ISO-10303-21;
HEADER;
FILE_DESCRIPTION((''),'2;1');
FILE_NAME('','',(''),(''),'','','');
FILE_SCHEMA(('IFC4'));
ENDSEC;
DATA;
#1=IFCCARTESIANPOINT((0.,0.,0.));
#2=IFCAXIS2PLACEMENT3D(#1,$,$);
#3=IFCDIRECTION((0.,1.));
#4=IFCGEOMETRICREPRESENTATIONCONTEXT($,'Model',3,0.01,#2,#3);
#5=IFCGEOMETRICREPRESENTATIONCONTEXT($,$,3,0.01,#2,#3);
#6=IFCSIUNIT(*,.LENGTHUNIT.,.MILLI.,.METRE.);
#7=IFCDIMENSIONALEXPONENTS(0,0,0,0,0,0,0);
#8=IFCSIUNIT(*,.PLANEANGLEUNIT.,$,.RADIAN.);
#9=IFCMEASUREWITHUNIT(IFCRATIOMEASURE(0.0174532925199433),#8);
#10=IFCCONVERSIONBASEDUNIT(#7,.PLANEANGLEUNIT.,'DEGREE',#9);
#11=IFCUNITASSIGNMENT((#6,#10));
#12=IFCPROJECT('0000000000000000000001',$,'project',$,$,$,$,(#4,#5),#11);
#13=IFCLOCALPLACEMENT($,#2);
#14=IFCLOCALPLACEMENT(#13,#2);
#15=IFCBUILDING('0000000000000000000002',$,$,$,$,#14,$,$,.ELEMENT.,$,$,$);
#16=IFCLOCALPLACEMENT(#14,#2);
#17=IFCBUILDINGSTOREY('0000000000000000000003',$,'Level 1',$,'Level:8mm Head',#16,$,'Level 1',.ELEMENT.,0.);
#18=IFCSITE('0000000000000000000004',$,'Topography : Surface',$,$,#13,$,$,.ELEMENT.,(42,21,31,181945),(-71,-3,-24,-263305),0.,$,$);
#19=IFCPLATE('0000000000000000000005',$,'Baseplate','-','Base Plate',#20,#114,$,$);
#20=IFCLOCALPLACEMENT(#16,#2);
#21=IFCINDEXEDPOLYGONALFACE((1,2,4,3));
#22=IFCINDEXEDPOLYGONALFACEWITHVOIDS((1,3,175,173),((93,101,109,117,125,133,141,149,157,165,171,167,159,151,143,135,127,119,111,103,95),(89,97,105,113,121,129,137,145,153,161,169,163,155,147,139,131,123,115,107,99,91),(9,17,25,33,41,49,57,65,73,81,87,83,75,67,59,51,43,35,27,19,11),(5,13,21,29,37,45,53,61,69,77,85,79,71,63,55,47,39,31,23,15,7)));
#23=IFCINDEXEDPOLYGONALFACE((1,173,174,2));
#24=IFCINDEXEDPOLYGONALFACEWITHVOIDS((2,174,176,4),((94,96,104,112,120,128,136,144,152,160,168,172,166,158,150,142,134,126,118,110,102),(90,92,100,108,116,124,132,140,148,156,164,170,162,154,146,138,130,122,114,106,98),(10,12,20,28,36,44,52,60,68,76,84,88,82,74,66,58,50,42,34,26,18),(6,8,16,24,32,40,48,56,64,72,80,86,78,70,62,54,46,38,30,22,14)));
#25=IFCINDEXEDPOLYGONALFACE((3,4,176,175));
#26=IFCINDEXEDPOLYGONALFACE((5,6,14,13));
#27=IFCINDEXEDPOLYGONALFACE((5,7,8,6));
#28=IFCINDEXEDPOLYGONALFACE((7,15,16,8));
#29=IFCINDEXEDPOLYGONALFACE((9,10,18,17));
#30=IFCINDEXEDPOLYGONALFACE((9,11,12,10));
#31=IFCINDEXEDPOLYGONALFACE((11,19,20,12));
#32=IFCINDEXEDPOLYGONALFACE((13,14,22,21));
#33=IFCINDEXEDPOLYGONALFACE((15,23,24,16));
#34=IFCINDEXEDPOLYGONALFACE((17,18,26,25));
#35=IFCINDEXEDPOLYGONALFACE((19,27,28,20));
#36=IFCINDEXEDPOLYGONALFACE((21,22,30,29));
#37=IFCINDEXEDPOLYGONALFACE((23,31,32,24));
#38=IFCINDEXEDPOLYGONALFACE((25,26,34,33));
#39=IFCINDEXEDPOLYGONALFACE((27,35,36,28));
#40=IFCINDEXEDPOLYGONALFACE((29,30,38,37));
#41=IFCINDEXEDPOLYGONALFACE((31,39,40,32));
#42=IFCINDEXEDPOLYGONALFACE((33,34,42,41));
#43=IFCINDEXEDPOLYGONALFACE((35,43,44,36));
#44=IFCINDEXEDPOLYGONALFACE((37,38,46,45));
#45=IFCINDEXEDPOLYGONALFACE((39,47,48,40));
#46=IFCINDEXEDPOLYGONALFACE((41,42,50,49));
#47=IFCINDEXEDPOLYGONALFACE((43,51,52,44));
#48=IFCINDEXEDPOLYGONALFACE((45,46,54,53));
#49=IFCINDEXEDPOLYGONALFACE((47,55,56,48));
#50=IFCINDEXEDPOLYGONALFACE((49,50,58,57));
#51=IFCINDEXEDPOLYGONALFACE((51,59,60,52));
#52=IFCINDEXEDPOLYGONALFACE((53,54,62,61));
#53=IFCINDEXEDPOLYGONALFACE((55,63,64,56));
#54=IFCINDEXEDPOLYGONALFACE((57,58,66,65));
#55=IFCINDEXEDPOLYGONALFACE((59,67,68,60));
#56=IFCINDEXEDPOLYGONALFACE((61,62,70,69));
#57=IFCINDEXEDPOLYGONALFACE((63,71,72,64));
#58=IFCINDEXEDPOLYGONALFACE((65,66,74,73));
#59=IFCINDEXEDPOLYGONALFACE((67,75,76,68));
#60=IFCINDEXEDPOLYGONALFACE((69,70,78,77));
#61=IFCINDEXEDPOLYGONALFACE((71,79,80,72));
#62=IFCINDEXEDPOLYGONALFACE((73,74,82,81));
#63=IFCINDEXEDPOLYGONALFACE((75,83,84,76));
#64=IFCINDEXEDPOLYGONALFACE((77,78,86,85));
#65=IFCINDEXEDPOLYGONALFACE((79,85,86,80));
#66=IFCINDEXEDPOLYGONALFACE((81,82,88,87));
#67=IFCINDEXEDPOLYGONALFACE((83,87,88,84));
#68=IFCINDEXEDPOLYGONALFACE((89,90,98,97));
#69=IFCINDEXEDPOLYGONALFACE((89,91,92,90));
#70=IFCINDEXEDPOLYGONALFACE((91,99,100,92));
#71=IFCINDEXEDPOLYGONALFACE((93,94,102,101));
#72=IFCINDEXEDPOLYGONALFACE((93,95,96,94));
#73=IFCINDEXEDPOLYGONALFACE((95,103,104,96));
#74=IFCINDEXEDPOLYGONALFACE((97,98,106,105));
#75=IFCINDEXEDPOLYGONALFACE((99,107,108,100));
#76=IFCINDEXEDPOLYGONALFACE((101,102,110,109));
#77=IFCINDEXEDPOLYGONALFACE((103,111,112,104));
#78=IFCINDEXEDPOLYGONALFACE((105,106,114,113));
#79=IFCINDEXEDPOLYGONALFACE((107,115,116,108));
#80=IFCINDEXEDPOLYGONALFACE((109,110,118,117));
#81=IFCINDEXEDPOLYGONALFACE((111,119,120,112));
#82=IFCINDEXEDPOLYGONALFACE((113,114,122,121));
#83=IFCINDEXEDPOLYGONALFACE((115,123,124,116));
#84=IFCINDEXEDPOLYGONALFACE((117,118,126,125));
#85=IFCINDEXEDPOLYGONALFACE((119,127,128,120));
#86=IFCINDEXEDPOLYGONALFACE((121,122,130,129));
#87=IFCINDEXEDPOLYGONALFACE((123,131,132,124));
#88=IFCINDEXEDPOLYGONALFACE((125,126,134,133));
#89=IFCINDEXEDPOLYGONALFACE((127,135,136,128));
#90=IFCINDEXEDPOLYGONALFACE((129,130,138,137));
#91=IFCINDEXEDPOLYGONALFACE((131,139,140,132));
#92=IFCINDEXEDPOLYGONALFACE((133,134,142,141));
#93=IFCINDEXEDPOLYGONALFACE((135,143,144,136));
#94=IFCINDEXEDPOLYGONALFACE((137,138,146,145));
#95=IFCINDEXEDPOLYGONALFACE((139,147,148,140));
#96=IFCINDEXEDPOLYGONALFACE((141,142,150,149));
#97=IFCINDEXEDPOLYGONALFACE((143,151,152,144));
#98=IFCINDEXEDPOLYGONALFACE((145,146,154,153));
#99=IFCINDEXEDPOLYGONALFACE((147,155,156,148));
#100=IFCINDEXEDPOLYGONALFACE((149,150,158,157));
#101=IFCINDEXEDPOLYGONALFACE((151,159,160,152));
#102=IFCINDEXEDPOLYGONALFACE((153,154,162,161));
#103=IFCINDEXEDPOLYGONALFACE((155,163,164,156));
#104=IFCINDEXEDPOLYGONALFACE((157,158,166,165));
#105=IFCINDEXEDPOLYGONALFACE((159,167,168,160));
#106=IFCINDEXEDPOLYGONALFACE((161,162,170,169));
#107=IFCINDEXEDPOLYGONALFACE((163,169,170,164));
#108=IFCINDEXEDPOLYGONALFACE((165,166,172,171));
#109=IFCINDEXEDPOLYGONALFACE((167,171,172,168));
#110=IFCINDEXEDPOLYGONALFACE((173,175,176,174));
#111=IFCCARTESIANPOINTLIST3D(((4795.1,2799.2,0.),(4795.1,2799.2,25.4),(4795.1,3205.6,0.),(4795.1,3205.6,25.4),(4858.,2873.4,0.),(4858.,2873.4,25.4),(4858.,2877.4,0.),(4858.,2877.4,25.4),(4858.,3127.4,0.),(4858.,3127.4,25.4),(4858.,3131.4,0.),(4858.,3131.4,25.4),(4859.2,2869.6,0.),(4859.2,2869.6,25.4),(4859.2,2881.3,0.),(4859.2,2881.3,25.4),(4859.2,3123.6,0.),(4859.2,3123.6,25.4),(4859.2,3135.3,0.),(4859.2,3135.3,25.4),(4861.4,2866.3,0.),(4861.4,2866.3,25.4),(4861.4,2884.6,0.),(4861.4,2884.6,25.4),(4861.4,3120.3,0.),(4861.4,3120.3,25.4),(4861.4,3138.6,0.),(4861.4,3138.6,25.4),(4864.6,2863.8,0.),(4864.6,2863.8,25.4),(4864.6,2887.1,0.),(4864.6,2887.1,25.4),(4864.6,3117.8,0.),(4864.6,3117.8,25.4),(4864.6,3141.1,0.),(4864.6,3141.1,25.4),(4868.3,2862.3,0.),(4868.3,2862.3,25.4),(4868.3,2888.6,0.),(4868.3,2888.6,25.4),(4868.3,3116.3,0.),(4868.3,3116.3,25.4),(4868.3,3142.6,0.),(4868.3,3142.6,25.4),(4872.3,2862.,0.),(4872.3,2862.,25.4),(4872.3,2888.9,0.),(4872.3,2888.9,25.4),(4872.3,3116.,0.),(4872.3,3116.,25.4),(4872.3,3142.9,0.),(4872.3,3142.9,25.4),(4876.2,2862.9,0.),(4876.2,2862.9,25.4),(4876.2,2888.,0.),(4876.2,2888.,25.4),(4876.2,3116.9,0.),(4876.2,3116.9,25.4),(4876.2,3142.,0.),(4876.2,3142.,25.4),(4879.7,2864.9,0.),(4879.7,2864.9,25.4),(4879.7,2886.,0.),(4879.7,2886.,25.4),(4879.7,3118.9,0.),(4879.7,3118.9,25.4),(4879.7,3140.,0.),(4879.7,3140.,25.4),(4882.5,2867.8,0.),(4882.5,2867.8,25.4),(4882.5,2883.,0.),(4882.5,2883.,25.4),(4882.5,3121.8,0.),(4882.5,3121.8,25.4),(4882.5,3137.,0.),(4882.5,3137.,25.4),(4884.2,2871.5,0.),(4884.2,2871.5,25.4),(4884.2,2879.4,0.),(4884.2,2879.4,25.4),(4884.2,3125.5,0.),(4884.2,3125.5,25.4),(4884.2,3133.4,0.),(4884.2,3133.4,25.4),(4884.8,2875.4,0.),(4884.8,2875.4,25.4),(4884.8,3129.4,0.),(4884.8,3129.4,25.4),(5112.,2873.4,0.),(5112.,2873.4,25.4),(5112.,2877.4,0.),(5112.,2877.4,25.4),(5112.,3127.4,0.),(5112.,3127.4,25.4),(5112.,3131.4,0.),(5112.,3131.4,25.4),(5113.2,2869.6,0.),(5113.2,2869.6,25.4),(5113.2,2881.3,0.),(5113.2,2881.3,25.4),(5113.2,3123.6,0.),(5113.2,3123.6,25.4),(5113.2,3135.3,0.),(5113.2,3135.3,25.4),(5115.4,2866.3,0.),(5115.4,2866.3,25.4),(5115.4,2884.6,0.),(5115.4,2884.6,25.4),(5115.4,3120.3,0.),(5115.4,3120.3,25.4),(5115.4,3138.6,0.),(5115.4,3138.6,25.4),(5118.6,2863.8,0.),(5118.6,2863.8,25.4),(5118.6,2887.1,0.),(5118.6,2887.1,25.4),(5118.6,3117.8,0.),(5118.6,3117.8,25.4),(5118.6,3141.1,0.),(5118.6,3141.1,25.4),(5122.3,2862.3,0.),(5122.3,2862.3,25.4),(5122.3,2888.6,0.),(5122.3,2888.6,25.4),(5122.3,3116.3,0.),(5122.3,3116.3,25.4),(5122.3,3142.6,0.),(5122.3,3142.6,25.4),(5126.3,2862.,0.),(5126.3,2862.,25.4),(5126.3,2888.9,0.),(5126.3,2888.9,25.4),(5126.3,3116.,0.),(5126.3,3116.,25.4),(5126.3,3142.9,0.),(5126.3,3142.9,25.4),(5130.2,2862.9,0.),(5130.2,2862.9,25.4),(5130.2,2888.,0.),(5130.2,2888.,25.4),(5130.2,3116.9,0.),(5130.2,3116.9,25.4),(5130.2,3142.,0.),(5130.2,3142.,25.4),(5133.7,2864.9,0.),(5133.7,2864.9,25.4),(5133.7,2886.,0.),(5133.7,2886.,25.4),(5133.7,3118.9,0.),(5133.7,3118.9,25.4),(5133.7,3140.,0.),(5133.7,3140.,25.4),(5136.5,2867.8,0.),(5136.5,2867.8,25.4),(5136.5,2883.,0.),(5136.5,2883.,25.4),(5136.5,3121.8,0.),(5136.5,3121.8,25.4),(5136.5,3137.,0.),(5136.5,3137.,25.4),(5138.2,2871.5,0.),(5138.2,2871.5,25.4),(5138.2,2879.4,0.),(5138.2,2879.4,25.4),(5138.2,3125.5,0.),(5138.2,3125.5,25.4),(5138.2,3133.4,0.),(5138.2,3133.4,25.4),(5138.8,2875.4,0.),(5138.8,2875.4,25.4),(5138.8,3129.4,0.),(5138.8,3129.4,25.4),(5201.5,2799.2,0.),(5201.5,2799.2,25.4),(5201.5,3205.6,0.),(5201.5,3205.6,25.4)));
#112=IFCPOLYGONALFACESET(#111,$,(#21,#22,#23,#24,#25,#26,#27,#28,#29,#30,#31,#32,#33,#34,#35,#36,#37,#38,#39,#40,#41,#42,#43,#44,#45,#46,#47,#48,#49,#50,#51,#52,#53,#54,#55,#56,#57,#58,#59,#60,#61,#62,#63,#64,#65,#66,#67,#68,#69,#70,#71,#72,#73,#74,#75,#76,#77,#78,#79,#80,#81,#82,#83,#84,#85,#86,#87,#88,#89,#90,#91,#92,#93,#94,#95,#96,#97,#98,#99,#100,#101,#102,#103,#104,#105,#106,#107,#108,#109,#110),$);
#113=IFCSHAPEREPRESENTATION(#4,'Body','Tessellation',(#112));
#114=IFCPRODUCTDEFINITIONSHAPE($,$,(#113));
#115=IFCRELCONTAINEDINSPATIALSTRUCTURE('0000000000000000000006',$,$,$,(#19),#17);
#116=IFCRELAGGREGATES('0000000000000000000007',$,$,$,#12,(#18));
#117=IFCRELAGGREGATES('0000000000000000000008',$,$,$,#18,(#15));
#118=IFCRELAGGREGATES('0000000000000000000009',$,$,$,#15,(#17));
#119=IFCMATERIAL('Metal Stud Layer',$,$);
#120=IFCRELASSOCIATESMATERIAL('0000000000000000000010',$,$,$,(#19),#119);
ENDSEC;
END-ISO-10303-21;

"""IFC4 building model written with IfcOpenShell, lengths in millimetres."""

from ifc_helpers import new_model, entity, si_unit, converted_unit, direction, frame, frame_2d, origin, origin_with_axes, place, context, project, spatial, polyline, circle, outline, extrude, material, element, save


model = new_model("IFC4")

# Units and contexts
model_context = context("Model", 3, precision=0.01, world=origin(), true_north=direction((0.0, 1.0)))
context_of_model = context(None, 3, precision=0.01, world=origin(), true_north=direction((0.0, 1.0)))
ifc_project = project(units=[si_unit("LENGTHUNIT", "METRE", prefix="MILLI"), converted_unit("PLANEANGLEUNIT", "DEGREE", entity("IfcRatioMeasure", 0.0174532925199433), si_unit("PLANEANGLEUNIT", "RADIAN"), dimensions=[0, 0, 0, 0, 0, 0, 0])], contexts=[model_context, context_of_model])

# Site, building, storey
site_placement = place(None, origin())
site = spatial("IfcSite", under=ifc_project, at=site_placement, Name="Topography : Surface", CompositionType="ELEMENT", RefLatitude=(42, 21, 31, 181945), RefLongitude=(-71, -3, -24, -263305), RefElevation=0.0)
building_placement = place(site_placement, origin())
building = spatial("IfcBuilding", under=site, at=building_placement, CompositionType="ELEMENT")
storey_placement = place(building_placement, origin())
storey = spatial("IfcBuildingStorey", under=building, at=storey_placement, Name="Level 1", ObjectType="Level:8mm Head", LongName="Level 1", CompositionType="ELEMENT", Elevation=0.0)

# Plate, openings
ifc_material_1 = material(Name="Metal Stud Layer")
plate_1_placement = place(storey_placement, frame((4795.1, 3205.6, 25.4), z_axis=(0.0, 0.0, -1.0), x_axis=(1.0, 0.0, 0.0)))
plate_1 = element("IfcPlate", 1, at=plate_1_placement, inside=storey, material=ifc_material_1, Name="Baseplate", Description="-", ObjectType="Base Plate", context=model_context, shape_type="SweptSolid", body=[
    extrude(outline(polyline([(0.0, 0.0), (406.4, 0.0), (406.4, 406.4), (0.0, 406.4), (0.0, 0.0)])), origin_with_axes(), (0.0, 0.0, 1.0), 25.4),
])
opening_1_placement = place(plate_1_placement, frame((203.2, 203.2, 25.9), z_axis=(0.0, 0.0, -1.0), x_axis=(1.0, 0.0, 0.0)))
element("IfcOpeningElement", 2, at=opening_1_placement, cuts=plate_1, ObjectType="Opening", context=model_context, shape_type="SweptSolid", body=[
    extrude(circle(Radius=13.5, at=frame_2d((127.0, 127.0), x_axis=(1.0, 0.0))), origin(), (0.0, 0.0, 1.0), 26.4),
])
opening_2_placement = place(plate_1_placement, frame((203.2, 203.2, 25.9), z_axis=(0.0, 0.0, -1.0), x_axis=(1.0, 0.0, 0.0)))
element("IfcOpeningElement", 3, at=opening_2_placement, cuts=plate_1, ObjectType="Opening", context=model_context, shape_type="SweptSolid", body=[
    extrude(circle(Radius=13.5, at=frame_2d((-127.0, 127.0), x_axis=(1.0, 0.0))), origin(), (0.0, 0.0, 1.0), 26.4),
])
opening_3_placement = place(plate_1_placement, frame((203.2, 203.2, 25.9), z_axis=(0.0, 0.0, -1.0), x_axis=(1.0, 0.0, 0.0)))
element("IfcOpeningElement", 4, at=opening_3_placement, cuts=plate_1, ObjectType="Opening", context=model_context, shape_type="SweptSolid", body=[
    extrude(circle(Radius=13.5, at=frame_2d((127.0, -127.0), x_axis=(1.0, 0.0))), origin(), (0.0, 0.0, 1.0), 26.4),
])
opening_4_placement = place(plate_1_placement, frame((203.2, 203.2, 25.9), z_axis=(0.0, 0.0, -1.0), x_axis=(1.0, 0.0, 0.0)))
element("IfcOpeningElement", 5, at=opening_4_placement, cuts=plate_1, ObjectType="Opening", context=model_context, shape_type="SweptSolid", body=[
    extrude(circle(Radius=13.5, at=frame_2d((-127.0, -127.0), x_axis=(1.0, 0.0))), origin(), (0.0, 0.0, 1.0), 26.4),
])

save(model, "model.ifc")
